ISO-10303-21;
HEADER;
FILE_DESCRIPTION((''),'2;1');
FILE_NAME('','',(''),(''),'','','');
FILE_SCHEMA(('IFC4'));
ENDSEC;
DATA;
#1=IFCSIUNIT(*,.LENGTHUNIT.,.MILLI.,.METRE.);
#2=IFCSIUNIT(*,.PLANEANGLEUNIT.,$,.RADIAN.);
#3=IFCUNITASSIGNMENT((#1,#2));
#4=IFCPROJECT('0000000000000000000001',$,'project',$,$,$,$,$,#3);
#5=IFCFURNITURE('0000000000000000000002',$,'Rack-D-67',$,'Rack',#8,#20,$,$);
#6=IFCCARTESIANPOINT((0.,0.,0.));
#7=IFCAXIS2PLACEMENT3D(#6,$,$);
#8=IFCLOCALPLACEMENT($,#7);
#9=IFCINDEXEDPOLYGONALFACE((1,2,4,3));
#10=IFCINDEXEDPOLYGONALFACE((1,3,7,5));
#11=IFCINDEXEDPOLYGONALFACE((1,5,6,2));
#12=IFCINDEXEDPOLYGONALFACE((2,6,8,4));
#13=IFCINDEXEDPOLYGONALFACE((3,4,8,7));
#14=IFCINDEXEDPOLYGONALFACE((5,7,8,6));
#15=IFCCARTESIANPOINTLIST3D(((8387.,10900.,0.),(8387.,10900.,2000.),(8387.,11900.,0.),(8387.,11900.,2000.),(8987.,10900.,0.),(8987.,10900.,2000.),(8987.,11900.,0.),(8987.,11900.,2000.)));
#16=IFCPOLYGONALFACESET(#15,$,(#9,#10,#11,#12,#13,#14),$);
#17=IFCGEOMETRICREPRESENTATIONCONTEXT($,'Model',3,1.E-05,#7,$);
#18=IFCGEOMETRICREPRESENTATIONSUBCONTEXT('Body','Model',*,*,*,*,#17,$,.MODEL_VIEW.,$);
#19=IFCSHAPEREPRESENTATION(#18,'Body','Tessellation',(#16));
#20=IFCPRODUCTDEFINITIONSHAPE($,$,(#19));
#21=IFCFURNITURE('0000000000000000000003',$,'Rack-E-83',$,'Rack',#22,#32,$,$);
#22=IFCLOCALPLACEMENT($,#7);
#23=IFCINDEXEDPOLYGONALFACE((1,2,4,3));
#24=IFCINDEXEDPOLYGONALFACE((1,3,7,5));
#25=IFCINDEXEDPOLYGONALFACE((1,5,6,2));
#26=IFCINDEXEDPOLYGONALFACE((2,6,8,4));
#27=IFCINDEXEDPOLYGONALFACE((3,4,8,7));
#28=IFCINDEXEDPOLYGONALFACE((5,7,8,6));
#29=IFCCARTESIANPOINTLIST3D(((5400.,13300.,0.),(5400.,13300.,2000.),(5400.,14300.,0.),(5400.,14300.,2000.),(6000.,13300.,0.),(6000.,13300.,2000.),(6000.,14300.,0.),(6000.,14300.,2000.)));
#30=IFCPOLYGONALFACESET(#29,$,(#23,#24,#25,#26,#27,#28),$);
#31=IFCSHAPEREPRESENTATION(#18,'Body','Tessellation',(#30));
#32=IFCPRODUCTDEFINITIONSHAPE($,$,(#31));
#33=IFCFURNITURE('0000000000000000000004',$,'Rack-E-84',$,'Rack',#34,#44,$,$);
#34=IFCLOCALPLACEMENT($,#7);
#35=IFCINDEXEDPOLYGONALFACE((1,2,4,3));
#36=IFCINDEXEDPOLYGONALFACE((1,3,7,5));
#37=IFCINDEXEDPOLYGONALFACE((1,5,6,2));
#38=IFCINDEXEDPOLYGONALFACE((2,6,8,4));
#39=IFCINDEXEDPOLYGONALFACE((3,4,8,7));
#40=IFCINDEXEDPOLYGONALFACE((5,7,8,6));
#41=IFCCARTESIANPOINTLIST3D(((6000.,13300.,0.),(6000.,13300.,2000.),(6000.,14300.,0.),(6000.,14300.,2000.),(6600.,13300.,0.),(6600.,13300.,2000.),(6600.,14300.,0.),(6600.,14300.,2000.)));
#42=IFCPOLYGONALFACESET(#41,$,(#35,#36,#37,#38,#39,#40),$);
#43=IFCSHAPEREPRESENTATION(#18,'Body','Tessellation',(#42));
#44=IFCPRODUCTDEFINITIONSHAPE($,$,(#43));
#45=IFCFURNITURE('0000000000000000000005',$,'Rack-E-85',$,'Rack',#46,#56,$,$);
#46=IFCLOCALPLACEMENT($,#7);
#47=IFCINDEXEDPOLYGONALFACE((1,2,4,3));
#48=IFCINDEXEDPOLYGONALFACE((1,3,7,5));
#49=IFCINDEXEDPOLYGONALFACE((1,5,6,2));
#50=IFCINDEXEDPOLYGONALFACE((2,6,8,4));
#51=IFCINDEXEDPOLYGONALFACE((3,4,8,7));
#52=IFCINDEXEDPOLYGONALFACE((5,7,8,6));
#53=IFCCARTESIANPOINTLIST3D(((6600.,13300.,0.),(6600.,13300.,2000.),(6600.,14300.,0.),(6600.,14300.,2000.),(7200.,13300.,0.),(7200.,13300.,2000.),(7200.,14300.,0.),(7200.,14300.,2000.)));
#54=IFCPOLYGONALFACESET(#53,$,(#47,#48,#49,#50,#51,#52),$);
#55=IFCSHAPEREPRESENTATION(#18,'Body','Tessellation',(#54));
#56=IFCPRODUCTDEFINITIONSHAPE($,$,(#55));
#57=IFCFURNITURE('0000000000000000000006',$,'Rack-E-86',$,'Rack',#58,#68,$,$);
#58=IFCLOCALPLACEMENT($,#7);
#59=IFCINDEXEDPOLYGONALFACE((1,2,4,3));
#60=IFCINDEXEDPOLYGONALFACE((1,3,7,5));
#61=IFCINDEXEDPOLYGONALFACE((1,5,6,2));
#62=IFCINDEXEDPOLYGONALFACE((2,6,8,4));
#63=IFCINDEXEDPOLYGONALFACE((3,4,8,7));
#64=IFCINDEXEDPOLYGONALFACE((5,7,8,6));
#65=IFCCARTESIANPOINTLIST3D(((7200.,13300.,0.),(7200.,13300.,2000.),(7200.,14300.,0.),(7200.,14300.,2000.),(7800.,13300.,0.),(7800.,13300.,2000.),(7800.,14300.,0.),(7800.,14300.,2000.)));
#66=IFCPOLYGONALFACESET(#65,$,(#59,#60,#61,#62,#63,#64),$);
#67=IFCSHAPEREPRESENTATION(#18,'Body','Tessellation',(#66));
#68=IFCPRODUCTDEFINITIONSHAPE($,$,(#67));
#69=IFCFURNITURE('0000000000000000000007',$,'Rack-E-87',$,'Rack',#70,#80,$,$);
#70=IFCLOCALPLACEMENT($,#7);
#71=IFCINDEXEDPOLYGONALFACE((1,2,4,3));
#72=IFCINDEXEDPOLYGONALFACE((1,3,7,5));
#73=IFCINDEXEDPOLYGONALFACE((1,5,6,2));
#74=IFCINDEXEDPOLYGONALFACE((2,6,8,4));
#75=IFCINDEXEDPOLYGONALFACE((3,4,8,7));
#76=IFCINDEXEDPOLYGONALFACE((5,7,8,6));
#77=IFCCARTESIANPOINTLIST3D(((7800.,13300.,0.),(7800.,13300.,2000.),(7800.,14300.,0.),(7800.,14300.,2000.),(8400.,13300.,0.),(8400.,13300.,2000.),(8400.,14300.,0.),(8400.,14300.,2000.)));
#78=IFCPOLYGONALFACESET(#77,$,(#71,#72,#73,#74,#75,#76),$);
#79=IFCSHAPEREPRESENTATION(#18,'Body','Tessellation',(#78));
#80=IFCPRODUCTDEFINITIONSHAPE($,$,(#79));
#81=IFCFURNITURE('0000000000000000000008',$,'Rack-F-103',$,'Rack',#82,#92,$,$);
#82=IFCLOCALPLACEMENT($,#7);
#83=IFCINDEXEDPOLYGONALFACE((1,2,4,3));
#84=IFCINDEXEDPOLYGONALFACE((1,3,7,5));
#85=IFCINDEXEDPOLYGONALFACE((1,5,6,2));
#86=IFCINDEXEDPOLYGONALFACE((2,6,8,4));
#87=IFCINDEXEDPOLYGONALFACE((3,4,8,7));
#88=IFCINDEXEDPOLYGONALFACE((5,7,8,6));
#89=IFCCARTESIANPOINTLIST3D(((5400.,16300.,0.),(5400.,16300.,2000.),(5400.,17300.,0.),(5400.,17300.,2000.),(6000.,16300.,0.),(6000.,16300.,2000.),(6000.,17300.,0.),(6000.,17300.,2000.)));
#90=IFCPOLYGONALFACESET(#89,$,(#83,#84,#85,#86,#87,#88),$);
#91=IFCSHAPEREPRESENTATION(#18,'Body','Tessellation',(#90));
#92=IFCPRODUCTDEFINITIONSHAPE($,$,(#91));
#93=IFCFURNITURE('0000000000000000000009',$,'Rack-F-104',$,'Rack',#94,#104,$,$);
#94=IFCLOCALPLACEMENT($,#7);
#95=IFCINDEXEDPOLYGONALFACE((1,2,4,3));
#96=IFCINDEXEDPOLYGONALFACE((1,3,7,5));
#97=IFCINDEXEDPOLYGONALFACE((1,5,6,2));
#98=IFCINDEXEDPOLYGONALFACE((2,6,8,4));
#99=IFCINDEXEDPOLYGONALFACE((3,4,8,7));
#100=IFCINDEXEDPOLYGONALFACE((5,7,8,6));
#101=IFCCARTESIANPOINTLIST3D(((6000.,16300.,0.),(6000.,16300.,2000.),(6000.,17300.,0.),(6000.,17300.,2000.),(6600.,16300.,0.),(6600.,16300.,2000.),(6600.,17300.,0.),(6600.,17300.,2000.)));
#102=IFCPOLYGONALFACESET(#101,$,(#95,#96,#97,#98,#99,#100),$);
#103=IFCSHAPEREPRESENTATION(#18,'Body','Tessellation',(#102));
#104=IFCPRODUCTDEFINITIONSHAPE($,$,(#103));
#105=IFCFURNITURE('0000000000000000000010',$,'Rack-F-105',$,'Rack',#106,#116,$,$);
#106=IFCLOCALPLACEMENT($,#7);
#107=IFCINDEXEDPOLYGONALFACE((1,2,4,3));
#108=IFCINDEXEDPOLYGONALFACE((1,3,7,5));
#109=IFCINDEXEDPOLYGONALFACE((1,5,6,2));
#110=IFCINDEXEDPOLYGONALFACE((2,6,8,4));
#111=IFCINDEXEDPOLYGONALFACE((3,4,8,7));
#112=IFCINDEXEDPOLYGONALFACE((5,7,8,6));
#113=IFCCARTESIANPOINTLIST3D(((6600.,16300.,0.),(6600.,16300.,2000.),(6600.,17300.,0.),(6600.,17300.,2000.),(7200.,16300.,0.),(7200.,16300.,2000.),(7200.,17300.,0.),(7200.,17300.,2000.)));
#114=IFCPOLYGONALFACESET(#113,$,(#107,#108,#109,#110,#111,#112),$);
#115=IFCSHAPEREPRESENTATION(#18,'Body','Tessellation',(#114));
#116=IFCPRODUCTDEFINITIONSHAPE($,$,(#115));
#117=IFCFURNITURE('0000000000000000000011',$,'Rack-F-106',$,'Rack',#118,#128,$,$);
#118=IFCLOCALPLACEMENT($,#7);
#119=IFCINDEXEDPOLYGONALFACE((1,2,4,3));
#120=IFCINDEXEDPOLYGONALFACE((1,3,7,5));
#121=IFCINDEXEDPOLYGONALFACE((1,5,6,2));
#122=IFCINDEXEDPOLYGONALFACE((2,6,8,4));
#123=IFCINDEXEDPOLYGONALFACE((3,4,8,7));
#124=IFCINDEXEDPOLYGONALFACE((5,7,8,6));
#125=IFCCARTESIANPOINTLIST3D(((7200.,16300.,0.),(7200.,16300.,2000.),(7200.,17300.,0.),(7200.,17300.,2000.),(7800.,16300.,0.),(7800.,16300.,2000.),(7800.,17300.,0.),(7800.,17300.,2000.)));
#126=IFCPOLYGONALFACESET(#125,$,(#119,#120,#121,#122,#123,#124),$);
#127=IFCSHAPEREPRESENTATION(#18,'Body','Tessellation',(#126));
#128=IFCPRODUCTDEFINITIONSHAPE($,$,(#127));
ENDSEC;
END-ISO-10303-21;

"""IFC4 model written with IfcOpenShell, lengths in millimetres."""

from ifc_helpers import new_model, si_unit, frame, origin, place, context, subcontext, project, rectangle, extrude, element, save


model = new_model("IFC4")

# Units and contexts
model_context = context("Model", 3, precision=1e-05, world=origin())
body_context = subcontext(model_context, "Body", "Model", "MODEL_VIEW")
ifc_project = project(units=[si_unit("LENGTHUNIT", "METRE", prefix="MILLI"), si_unit("PLANEANGLEUNIT", "RADIAN")])

# Furniture
for number, where, name in (
    (1, (8687.0, 11400.0, 0.0), "Rack-D-67"),
    (2, (5700.0, 13800.0, 0.0), "Rack-E-83"),
    (3, (6300.0, 13800.0, 0.0), "Rack-E-84"),
    (4, (6900.0, 13800.0, 0.0), "Rack-E-85"),
    (5, (7500.0, 13800.0, 0.0), "Rack-E-86"),
    (6, (8100.0, 13800.0, 0.0), "Rack-E-87"),
    (7, (5700.0, 16800.0, 0.0), "Rack-F-103"),
    (8, (6300.0, 16800.0, 0.0), "Rack-F-104"),
    (9, (6900.0, 16800.0, 0.0), "Rack-F-105"),
    (10, (7500.0, 16800.0, 0.0), "Rack-F-106"),
):
    element("IfcFurniture", number, at=place(None, frame(where)), Name=name, ObjectType="Rack", context=body_context, shape_type="SweptSolid", body=[
        extrude(rectangle(XDim=600.0, YDim=1000.0), None, (0.0, 0.0, 1.0), 2000.0),
    ])

save(model, "model.ifc")
